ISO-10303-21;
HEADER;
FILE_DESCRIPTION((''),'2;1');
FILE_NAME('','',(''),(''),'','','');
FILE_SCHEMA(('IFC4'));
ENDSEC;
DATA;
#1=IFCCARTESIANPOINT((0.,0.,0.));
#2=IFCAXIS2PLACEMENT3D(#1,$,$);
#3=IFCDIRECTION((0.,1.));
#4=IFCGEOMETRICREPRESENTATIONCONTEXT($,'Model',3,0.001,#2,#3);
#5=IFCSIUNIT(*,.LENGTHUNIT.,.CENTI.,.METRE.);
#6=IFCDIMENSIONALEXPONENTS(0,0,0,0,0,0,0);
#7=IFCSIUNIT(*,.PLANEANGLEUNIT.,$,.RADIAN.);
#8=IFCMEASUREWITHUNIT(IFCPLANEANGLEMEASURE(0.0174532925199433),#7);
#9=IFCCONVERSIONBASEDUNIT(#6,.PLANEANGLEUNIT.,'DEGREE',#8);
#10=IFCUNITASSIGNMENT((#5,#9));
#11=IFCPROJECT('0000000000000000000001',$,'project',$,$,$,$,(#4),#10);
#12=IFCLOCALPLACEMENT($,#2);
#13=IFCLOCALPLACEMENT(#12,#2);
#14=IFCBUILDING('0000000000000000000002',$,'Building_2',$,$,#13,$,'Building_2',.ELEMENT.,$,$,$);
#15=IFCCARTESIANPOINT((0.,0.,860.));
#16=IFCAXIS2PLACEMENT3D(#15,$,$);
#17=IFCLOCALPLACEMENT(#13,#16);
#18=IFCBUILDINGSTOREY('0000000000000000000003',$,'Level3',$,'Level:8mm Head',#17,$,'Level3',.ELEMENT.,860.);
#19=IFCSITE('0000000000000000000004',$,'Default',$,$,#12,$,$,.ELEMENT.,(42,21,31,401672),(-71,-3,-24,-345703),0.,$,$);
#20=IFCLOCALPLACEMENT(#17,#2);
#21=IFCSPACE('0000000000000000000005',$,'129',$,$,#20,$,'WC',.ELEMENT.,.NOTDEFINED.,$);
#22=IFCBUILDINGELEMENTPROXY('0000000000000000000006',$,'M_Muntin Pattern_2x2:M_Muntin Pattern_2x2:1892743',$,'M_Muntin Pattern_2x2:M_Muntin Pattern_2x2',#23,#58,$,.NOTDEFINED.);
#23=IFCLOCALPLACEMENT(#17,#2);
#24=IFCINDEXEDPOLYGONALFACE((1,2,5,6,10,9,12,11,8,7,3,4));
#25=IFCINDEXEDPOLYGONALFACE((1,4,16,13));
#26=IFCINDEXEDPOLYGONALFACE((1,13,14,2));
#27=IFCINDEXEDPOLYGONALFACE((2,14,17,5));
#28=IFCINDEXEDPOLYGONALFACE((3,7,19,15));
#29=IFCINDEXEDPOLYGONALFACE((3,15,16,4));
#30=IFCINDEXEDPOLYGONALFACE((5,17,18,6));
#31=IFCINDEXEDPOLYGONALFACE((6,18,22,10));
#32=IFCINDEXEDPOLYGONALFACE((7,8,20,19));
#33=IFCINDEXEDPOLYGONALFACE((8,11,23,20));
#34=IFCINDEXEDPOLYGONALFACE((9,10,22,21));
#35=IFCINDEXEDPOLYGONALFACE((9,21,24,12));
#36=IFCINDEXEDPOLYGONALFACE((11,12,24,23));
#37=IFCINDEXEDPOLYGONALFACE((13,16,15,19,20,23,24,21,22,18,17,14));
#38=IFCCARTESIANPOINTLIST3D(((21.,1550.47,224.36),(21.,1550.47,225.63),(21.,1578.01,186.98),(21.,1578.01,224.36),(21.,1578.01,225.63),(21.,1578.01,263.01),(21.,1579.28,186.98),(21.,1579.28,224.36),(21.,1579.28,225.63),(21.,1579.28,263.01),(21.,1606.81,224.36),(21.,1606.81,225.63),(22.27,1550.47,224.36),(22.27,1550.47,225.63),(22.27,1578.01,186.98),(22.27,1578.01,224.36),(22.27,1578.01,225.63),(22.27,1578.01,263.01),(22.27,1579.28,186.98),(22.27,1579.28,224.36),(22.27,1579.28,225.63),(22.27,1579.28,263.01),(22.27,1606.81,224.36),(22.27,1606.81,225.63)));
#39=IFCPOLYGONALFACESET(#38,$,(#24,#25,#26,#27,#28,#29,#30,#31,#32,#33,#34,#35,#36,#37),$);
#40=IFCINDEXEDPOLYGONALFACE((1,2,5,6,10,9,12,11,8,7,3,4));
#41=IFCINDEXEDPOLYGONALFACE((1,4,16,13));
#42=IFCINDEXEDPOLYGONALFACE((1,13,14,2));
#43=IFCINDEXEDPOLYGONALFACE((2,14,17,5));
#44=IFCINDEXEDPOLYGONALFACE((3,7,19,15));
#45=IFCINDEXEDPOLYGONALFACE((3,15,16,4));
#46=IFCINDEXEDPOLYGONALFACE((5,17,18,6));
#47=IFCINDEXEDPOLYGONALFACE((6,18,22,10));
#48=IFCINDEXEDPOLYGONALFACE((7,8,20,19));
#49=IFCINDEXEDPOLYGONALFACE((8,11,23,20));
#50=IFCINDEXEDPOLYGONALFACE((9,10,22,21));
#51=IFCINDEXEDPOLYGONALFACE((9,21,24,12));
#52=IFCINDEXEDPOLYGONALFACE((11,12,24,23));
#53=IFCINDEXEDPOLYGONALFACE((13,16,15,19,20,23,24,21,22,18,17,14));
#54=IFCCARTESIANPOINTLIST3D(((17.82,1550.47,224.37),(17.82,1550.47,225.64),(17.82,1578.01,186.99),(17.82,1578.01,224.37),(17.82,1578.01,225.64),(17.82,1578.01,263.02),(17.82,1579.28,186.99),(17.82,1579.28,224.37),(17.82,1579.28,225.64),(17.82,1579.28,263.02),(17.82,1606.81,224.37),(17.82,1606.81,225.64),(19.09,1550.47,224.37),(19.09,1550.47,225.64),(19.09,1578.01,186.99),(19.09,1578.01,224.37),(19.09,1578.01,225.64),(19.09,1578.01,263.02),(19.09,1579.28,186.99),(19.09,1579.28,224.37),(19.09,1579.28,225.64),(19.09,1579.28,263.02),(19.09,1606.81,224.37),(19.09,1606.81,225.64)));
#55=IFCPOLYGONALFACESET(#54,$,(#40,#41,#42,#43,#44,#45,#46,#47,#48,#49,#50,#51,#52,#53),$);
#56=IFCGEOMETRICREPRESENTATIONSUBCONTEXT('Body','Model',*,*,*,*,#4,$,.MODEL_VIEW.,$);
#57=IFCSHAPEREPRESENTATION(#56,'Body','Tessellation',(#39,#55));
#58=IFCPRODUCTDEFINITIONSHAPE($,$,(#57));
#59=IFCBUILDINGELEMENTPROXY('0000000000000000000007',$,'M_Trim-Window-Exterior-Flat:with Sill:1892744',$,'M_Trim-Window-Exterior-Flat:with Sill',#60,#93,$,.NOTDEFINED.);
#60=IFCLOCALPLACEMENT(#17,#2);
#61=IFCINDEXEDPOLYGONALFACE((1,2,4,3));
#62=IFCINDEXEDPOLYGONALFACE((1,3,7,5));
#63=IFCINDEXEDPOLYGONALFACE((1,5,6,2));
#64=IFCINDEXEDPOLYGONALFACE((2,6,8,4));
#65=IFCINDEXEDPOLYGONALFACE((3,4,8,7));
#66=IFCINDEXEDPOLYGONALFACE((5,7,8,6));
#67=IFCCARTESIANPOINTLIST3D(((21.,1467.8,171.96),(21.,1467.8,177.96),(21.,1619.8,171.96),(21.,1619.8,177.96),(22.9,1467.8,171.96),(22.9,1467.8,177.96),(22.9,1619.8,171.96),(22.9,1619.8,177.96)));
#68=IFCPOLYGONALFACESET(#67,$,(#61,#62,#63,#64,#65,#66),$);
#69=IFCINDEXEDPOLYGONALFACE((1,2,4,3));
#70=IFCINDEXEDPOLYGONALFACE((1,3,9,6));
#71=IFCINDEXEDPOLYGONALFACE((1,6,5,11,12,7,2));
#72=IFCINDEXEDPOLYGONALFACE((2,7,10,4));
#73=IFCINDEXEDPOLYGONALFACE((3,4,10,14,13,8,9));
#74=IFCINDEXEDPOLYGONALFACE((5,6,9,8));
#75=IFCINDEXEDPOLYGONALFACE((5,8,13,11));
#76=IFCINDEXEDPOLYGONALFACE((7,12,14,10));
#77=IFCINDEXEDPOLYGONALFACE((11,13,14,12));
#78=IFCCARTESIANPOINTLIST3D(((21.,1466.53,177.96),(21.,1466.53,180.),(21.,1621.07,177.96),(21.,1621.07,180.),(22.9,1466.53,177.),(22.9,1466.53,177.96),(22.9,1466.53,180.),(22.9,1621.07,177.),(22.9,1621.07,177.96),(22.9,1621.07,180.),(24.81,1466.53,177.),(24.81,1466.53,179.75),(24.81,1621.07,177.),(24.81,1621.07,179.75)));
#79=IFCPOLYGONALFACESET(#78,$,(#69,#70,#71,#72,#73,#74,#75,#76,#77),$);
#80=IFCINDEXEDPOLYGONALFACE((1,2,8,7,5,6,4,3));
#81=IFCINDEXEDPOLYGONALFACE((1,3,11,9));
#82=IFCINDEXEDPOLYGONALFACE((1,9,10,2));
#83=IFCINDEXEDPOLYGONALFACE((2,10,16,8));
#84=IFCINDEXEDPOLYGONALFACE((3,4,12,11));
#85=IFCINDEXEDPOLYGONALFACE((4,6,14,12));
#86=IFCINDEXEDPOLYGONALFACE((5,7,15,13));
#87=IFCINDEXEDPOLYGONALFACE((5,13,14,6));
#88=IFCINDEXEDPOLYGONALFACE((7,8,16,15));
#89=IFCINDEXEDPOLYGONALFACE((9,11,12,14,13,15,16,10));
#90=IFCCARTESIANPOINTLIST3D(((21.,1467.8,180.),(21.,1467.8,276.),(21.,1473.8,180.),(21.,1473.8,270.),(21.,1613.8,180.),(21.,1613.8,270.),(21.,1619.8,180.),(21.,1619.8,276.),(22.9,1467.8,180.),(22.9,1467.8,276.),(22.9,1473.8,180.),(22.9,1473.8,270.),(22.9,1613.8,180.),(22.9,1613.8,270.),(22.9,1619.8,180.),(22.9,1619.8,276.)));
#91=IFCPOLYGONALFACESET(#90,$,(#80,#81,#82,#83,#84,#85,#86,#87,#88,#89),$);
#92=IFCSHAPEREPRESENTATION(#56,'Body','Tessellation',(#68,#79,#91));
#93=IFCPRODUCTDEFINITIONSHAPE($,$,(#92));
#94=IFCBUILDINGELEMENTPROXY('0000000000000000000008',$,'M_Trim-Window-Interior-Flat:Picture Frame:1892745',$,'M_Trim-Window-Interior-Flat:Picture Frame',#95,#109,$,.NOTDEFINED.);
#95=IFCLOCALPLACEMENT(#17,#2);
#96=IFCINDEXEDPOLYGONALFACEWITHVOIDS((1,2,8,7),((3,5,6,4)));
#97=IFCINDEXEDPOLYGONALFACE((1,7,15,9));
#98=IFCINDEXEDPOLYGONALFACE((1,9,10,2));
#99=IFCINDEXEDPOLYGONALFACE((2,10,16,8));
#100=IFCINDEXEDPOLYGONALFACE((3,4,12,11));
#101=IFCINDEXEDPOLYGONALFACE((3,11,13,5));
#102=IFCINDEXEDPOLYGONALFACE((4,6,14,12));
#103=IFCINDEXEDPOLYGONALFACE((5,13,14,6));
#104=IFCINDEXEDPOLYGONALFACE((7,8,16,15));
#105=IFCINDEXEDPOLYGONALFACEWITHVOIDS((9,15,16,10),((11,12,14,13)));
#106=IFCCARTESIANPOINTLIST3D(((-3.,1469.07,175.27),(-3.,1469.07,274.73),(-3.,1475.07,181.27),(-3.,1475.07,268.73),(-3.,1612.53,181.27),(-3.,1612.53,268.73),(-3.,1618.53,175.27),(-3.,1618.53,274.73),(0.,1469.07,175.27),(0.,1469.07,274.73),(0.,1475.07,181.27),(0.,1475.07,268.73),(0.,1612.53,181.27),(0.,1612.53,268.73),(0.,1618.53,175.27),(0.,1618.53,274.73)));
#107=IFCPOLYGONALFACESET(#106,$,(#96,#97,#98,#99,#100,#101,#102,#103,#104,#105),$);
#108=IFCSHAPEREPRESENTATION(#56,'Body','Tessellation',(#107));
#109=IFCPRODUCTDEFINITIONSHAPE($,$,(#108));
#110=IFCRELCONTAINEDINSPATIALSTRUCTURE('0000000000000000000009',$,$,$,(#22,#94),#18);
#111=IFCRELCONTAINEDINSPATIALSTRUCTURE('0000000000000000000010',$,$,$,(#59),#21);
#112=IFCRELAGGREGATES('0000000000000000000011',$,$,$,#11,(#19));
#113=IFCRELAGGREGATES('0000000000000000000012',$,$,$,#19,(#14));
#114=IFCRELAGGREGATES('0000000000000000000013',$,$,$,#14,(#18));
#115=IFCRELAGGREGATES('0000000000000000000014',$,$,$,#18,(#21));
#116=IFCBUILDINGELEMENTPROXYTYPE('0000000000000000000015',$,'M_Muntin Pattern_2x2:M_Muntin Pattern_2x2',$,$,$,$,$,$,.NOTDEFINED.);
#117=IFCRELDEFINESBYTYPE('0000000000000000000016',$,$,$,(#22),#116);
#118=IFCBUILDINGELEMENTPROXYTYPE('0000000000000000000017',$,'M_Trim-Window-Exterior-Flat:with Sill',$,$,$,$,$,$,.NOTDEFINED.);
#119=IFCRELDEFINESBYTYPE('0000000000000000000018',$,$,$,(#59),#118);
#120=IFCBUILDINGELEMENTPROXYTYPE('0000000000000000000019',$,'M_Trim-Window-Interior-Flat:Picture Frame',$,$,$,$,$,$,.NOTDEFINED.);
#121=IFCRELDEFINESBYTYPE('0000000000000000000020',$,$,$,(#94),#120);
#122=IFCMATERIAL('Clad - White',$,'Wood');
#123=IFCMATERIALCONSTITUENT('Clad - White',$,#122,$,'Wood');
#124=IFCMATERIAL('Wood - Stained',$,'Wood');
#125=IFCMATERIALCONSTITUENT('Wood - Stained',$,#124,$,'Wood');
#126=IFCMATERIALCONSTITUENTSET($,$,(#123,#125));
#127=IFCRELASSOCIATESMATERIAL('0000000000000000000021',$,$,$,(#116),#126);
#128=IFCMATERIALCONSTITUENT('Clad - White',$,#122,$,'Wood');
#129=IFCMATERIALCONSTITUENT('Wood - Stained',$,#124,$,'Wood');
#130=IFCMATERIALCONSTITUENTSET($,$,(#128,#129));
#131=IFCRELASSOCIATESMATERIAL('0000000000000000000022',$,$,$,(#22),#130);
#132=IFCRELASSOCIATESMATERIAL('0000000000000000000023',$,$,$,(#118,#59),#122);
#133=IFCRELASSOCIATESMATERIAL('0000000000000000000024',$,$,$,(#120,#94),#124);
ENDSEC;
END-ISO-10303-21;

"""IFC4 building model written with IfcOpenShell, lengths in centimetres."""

from ifc_helpers import new_model, entity, si_unit, converted_unit, direction, frame, origin, place, context, subcontext, project, spatial, indexed_curve, outline, extrude, source, transform, mapped, material, constituent, constituent_set, type_object, type_shapes, element, save


model = new_model("IFC4")

# Units and contexts
model_context = context("Model", 3, precision=0.001, world=origin(), true_north=direction((0.0, 1.0)))
body_context = subcontext(model_context, "Body", "Model", "MODEL_VIEW")
ifc_project = project(units=[si_unit("LENGTHUNIT", "METRE", prefix="CENTI"), converted_unit("PLANEANGLEUNIT", "DEGREE", entity("IfcPlaneAngleMeasure", 0.0174532925199433), si_unit("PLANEANGLEUNIT", "RADIAN"), dimensions=[0, 0, 0, 0, 0, 0, 0])], contexts=[model_context])

# Site, building, storey
site_placement = place(None, origin())
site = spatial("IfcSite", under=ifc_project, at=site_placement, Name="Default", CompositionType="ELEMENT", RefLatitude=(42, 21, 31, 401672), RefLongitude=(-71, -3, -24, -345703), RefElevation=0.0)
building_placement = place(site_placement, origin())
building = spatial("IfcBuilding", under=site, at=building_placement, Name="Building_2", LongName="Building_2", CompositionType="ELEMENT")
storey_placement = place(building_placement, frame((0.0, 0.0, 860.0)))
storey = spatial("IfcBuildingStorey", under=building, at=storey_placement, Name="Level3", ObjectType="Level:8mm Head", LongName="Level3", CompositionType="ELEMENT", Elevation=860.0)

# Shared definitions
ifc_material_1 = material(Name="Clad - White", Category="Wood")
ifc_material_2 = material(Name="Wood - Stained", Category="Wood")

# Building element proxy
ifc_constituent_1 = constituent(ifc_material_1, Name="Clad - White", Category="Wood")
ifc_constituent_2 = constituent(ifc_material_2, Name="Wood - Stained", Category="Wood")
ifc_constituent_set_1 = constituent_set(constituents=[ifc_constituent_1, ifc_constituent_2])
ifc_constituent_3 = constituent(ifc_material_1, Name="Clad - White", Category="Wood")
ifc_constituent_4 = constituent(ifc_material_2, Name="Wood - Stained", Category="Wood")
ifc_constituent_set_2 = constituent_set(constituents=[ifc_constituent_3, ifc_constituent_4])
building_element_proxy_type_1 = type_object("IfcBuildingElementProxyType", Name="M_Muntin Pattern_2x2:M_Muntin Pattern_2x2", PredefinedType="NOTDEFINED", material=ifc_constituent_set_2)
shared_shape_1 = source(origin(), body_context, "Body", "SweptSolid", [
    extrude(outline(indexed_curve([(0.64, -0.64), (38.01, -0.64), (38.01, 0.63), (0.64, 0.63), (0.64, 28.17), (-0.63, 28.17), (-0.63, 0.63), (-38.02, 0.63), (-38.02, -0.64), (-0.63, -0.64), (-0.63, -28.17), (0.64, -28.17), (0.64, -0.64)], self_intersect=False)), frame((0.0, 0.95, 38.01), z_axis=(0.0, 1.0, 0.0), x_axis=(0.0, 0.0, 1.0)), (0.0, 0.0, 1.0), 1.27),
    extrude(outline(indexed_curve([(0.64, -0.64), (38.02, -0.64), (38.02, 0.63), (0.64, 0.63), (0.64, 28.17), (-0.63, 28.17), (-0.63, 0.63), (-38.02, 0.63), (-38.02, -0.64), (-0.63, -0.64), (-0.63, -28.17), (0.64, -28.17), (0.64, -0.64)], self_intersect=False)), frame((0.0, -2.22, 38.02), z_axis=(0.0, 1.0, 0.0), x_axis=(0.0, 0.0, 1.0)), (0.0, 0.0, 1.0), 1.27),
])
type_shapes(building_element_proxy_type_1, [shared_shape_1])
proxy_1_placement = place(storey_placement, frame((20.05, 1578.64, 186.99), z_axis=(0.0, 0.0, 1.0), x_axis=(0.0, -1.0, 0.0)))
element("IfcBuildingElementProxy", 1, at=proxy_1_placement, inside=storey, type_object=building_element_proxy_type_1, material=ifc_constituent_set_1, Name="M_Muntin Pattern_2x2:M_Muntin Pattern_2x2:1892743", ObjectType="M_Muntin Pattern_2x2:M_Muntin Pattern_2x2", PredefinedType="NOTDEFINED", context=body_context, shape_type="MappedRepresentation", body=[
    mapped(shared_shape_1, transform((0.0, 0.0, 0.0), scale=1.0)),
])

# Shared definitions
space_1_placement = place(storey_placement, origin())
space_1 = spatial("IfcSpace", under=storey, at=space_1_placement, Name="129", LongName="WC", CompositionType="ELEMENT", PredefinedType="NOTDEFINED")

# Building element proxies
building_element_proxy_type_2 = type_object("IfcBuildingElementProxyType", Name="M_Trim-Window-Exterior-Flat:with Sill", PredefinedType="NOTDEFINED", material=ifc_material_1)
shared_shape_2 = source(origin(), body_context, "Body", "SweptSolid", [
    extrude(outline(indexed_curve([(-3.0, -76.0), (3.0, -76.0), (3.0, 76.0), (-3.0, 76.0), (-3.0, -76.0)], self_intersect=False)), frame((0.0, 95.04, 0.0), z_axis=(0.0, 0.0, 1.0), x_axis=(0.0, 1.0, 0.0)), (0.0, 0.0, 1.0), 1.91),
    extrude(outline(indexed_curve([(-1.52, -1.9), (1.23, -1.9), (1.48, 0.0), (1.48, 1.9), (-0.57, 1.9), (-0.57, 0.0), (-1.52, 0.0), (-1.52, -1.9)], self_intersect=False)), frame((-77.27, 91.48, 1.9), z_axis=(1.0, 0.0, 0.0), x_axis=(0.0, -1.0, 0.0)), (0.0, 0.0, 1.0), 154.54),
    extrude(outline(indexed_curve([(-76.0, -49.5), (76.0, -49.5), (76.0, 46.5), (70.0, 46.5), (70.0, -43.5), (-70.0, -43.5), (-70.0, 46.5), (-76.0, 46.5), (-76.0, -49.5)], self_intersect=False)), frame((0.0, 43.5, 0.0)), (0.0, 0.0, 1.0), 1.91),
])
type_shapes(building_element_proxy_type_2, [shared_shape_2])
proxy_2_placement = place(space_1_placement, frame((21.0, 1543.8, 270.0), z_axis=(1.0, 0.0, 0.0), x_axis=(0.0, -1.0, 0.0)))
element("IfcBuildingElementProxy", 2, at=proxy_2_placement, inside=space_1, type_object=building_element_proxy_type_2, material=ifc_material_1, Name="M_Trim-Window-Exterior-Flat:with Sill:1892744", ObjectType="M_Trim-Window-Exterior-Flat:with Sill", PredefinedType="NOTDEFINED", context=body_context, shape_type="MappedRepresentation", body=[
    mapped(shared_shape_2, transform((0.0, 0.0, 0.0), scale=1.0)),
])
building_element_proxy_type_3 = type_object("IfcBuildingElementProxyType", Name="M_Trim-Window-Interior-Flat:Picture Frame", PredefinedType="NOTDEFINED", material=ifc_material_2)
shared_shape_3 = source(origin(), body_context, "Body", "SweptSolid", [
    extrude(outline(indexed_curve([(-49.73, -74.73), (49.73, -74.73), (49.73, 74.73), (-49.73, 74.73), (-49.73, -74.73)], self_intersect=False), holes=[indexed_curve([(-43.73, -68.73), (-43.73, 68.73), (43.73, 68.73), (43.73, -68.73), (-43.73, -68.73)], self_intersect=False)]), frame((0.0, 45.0, 0.0), z_axis=(0.0, 0.0, 1.0), x_axis=(0.0, 1.0, 0.0)), (0.0, 0.0, 1.0), 3.0),
])
type_shapes(building_element_proxy_type_3, [shared_shape_3])
proxy_3_placement = place(storey_placement, frame((0.0, 1543.8, 270.0), z_axis=(-1.0, 0.0, 0.0), x_axis=(0.0, 1.0, 0.0)))
element("IfcBuildingElementProxy", 3, at=proxy_3_placement, inside=storey, type_object=building_element_proxy_type_3, material=ifc_material_2, Name="M_Trim-Window-Interior-Flat:Picture Frame:1892745", ObjectType="M_Trim-Window-Interior-Flat:Picture Frame", PredefinedType="NOTDEFINED", context=body_context, shape_type="MappedRepresentation", body=[
    mapped(shared_shape_3, transform((0.0, 0.0, 0.0), scale=1.0)),
])

save(model, "model.ifc")
